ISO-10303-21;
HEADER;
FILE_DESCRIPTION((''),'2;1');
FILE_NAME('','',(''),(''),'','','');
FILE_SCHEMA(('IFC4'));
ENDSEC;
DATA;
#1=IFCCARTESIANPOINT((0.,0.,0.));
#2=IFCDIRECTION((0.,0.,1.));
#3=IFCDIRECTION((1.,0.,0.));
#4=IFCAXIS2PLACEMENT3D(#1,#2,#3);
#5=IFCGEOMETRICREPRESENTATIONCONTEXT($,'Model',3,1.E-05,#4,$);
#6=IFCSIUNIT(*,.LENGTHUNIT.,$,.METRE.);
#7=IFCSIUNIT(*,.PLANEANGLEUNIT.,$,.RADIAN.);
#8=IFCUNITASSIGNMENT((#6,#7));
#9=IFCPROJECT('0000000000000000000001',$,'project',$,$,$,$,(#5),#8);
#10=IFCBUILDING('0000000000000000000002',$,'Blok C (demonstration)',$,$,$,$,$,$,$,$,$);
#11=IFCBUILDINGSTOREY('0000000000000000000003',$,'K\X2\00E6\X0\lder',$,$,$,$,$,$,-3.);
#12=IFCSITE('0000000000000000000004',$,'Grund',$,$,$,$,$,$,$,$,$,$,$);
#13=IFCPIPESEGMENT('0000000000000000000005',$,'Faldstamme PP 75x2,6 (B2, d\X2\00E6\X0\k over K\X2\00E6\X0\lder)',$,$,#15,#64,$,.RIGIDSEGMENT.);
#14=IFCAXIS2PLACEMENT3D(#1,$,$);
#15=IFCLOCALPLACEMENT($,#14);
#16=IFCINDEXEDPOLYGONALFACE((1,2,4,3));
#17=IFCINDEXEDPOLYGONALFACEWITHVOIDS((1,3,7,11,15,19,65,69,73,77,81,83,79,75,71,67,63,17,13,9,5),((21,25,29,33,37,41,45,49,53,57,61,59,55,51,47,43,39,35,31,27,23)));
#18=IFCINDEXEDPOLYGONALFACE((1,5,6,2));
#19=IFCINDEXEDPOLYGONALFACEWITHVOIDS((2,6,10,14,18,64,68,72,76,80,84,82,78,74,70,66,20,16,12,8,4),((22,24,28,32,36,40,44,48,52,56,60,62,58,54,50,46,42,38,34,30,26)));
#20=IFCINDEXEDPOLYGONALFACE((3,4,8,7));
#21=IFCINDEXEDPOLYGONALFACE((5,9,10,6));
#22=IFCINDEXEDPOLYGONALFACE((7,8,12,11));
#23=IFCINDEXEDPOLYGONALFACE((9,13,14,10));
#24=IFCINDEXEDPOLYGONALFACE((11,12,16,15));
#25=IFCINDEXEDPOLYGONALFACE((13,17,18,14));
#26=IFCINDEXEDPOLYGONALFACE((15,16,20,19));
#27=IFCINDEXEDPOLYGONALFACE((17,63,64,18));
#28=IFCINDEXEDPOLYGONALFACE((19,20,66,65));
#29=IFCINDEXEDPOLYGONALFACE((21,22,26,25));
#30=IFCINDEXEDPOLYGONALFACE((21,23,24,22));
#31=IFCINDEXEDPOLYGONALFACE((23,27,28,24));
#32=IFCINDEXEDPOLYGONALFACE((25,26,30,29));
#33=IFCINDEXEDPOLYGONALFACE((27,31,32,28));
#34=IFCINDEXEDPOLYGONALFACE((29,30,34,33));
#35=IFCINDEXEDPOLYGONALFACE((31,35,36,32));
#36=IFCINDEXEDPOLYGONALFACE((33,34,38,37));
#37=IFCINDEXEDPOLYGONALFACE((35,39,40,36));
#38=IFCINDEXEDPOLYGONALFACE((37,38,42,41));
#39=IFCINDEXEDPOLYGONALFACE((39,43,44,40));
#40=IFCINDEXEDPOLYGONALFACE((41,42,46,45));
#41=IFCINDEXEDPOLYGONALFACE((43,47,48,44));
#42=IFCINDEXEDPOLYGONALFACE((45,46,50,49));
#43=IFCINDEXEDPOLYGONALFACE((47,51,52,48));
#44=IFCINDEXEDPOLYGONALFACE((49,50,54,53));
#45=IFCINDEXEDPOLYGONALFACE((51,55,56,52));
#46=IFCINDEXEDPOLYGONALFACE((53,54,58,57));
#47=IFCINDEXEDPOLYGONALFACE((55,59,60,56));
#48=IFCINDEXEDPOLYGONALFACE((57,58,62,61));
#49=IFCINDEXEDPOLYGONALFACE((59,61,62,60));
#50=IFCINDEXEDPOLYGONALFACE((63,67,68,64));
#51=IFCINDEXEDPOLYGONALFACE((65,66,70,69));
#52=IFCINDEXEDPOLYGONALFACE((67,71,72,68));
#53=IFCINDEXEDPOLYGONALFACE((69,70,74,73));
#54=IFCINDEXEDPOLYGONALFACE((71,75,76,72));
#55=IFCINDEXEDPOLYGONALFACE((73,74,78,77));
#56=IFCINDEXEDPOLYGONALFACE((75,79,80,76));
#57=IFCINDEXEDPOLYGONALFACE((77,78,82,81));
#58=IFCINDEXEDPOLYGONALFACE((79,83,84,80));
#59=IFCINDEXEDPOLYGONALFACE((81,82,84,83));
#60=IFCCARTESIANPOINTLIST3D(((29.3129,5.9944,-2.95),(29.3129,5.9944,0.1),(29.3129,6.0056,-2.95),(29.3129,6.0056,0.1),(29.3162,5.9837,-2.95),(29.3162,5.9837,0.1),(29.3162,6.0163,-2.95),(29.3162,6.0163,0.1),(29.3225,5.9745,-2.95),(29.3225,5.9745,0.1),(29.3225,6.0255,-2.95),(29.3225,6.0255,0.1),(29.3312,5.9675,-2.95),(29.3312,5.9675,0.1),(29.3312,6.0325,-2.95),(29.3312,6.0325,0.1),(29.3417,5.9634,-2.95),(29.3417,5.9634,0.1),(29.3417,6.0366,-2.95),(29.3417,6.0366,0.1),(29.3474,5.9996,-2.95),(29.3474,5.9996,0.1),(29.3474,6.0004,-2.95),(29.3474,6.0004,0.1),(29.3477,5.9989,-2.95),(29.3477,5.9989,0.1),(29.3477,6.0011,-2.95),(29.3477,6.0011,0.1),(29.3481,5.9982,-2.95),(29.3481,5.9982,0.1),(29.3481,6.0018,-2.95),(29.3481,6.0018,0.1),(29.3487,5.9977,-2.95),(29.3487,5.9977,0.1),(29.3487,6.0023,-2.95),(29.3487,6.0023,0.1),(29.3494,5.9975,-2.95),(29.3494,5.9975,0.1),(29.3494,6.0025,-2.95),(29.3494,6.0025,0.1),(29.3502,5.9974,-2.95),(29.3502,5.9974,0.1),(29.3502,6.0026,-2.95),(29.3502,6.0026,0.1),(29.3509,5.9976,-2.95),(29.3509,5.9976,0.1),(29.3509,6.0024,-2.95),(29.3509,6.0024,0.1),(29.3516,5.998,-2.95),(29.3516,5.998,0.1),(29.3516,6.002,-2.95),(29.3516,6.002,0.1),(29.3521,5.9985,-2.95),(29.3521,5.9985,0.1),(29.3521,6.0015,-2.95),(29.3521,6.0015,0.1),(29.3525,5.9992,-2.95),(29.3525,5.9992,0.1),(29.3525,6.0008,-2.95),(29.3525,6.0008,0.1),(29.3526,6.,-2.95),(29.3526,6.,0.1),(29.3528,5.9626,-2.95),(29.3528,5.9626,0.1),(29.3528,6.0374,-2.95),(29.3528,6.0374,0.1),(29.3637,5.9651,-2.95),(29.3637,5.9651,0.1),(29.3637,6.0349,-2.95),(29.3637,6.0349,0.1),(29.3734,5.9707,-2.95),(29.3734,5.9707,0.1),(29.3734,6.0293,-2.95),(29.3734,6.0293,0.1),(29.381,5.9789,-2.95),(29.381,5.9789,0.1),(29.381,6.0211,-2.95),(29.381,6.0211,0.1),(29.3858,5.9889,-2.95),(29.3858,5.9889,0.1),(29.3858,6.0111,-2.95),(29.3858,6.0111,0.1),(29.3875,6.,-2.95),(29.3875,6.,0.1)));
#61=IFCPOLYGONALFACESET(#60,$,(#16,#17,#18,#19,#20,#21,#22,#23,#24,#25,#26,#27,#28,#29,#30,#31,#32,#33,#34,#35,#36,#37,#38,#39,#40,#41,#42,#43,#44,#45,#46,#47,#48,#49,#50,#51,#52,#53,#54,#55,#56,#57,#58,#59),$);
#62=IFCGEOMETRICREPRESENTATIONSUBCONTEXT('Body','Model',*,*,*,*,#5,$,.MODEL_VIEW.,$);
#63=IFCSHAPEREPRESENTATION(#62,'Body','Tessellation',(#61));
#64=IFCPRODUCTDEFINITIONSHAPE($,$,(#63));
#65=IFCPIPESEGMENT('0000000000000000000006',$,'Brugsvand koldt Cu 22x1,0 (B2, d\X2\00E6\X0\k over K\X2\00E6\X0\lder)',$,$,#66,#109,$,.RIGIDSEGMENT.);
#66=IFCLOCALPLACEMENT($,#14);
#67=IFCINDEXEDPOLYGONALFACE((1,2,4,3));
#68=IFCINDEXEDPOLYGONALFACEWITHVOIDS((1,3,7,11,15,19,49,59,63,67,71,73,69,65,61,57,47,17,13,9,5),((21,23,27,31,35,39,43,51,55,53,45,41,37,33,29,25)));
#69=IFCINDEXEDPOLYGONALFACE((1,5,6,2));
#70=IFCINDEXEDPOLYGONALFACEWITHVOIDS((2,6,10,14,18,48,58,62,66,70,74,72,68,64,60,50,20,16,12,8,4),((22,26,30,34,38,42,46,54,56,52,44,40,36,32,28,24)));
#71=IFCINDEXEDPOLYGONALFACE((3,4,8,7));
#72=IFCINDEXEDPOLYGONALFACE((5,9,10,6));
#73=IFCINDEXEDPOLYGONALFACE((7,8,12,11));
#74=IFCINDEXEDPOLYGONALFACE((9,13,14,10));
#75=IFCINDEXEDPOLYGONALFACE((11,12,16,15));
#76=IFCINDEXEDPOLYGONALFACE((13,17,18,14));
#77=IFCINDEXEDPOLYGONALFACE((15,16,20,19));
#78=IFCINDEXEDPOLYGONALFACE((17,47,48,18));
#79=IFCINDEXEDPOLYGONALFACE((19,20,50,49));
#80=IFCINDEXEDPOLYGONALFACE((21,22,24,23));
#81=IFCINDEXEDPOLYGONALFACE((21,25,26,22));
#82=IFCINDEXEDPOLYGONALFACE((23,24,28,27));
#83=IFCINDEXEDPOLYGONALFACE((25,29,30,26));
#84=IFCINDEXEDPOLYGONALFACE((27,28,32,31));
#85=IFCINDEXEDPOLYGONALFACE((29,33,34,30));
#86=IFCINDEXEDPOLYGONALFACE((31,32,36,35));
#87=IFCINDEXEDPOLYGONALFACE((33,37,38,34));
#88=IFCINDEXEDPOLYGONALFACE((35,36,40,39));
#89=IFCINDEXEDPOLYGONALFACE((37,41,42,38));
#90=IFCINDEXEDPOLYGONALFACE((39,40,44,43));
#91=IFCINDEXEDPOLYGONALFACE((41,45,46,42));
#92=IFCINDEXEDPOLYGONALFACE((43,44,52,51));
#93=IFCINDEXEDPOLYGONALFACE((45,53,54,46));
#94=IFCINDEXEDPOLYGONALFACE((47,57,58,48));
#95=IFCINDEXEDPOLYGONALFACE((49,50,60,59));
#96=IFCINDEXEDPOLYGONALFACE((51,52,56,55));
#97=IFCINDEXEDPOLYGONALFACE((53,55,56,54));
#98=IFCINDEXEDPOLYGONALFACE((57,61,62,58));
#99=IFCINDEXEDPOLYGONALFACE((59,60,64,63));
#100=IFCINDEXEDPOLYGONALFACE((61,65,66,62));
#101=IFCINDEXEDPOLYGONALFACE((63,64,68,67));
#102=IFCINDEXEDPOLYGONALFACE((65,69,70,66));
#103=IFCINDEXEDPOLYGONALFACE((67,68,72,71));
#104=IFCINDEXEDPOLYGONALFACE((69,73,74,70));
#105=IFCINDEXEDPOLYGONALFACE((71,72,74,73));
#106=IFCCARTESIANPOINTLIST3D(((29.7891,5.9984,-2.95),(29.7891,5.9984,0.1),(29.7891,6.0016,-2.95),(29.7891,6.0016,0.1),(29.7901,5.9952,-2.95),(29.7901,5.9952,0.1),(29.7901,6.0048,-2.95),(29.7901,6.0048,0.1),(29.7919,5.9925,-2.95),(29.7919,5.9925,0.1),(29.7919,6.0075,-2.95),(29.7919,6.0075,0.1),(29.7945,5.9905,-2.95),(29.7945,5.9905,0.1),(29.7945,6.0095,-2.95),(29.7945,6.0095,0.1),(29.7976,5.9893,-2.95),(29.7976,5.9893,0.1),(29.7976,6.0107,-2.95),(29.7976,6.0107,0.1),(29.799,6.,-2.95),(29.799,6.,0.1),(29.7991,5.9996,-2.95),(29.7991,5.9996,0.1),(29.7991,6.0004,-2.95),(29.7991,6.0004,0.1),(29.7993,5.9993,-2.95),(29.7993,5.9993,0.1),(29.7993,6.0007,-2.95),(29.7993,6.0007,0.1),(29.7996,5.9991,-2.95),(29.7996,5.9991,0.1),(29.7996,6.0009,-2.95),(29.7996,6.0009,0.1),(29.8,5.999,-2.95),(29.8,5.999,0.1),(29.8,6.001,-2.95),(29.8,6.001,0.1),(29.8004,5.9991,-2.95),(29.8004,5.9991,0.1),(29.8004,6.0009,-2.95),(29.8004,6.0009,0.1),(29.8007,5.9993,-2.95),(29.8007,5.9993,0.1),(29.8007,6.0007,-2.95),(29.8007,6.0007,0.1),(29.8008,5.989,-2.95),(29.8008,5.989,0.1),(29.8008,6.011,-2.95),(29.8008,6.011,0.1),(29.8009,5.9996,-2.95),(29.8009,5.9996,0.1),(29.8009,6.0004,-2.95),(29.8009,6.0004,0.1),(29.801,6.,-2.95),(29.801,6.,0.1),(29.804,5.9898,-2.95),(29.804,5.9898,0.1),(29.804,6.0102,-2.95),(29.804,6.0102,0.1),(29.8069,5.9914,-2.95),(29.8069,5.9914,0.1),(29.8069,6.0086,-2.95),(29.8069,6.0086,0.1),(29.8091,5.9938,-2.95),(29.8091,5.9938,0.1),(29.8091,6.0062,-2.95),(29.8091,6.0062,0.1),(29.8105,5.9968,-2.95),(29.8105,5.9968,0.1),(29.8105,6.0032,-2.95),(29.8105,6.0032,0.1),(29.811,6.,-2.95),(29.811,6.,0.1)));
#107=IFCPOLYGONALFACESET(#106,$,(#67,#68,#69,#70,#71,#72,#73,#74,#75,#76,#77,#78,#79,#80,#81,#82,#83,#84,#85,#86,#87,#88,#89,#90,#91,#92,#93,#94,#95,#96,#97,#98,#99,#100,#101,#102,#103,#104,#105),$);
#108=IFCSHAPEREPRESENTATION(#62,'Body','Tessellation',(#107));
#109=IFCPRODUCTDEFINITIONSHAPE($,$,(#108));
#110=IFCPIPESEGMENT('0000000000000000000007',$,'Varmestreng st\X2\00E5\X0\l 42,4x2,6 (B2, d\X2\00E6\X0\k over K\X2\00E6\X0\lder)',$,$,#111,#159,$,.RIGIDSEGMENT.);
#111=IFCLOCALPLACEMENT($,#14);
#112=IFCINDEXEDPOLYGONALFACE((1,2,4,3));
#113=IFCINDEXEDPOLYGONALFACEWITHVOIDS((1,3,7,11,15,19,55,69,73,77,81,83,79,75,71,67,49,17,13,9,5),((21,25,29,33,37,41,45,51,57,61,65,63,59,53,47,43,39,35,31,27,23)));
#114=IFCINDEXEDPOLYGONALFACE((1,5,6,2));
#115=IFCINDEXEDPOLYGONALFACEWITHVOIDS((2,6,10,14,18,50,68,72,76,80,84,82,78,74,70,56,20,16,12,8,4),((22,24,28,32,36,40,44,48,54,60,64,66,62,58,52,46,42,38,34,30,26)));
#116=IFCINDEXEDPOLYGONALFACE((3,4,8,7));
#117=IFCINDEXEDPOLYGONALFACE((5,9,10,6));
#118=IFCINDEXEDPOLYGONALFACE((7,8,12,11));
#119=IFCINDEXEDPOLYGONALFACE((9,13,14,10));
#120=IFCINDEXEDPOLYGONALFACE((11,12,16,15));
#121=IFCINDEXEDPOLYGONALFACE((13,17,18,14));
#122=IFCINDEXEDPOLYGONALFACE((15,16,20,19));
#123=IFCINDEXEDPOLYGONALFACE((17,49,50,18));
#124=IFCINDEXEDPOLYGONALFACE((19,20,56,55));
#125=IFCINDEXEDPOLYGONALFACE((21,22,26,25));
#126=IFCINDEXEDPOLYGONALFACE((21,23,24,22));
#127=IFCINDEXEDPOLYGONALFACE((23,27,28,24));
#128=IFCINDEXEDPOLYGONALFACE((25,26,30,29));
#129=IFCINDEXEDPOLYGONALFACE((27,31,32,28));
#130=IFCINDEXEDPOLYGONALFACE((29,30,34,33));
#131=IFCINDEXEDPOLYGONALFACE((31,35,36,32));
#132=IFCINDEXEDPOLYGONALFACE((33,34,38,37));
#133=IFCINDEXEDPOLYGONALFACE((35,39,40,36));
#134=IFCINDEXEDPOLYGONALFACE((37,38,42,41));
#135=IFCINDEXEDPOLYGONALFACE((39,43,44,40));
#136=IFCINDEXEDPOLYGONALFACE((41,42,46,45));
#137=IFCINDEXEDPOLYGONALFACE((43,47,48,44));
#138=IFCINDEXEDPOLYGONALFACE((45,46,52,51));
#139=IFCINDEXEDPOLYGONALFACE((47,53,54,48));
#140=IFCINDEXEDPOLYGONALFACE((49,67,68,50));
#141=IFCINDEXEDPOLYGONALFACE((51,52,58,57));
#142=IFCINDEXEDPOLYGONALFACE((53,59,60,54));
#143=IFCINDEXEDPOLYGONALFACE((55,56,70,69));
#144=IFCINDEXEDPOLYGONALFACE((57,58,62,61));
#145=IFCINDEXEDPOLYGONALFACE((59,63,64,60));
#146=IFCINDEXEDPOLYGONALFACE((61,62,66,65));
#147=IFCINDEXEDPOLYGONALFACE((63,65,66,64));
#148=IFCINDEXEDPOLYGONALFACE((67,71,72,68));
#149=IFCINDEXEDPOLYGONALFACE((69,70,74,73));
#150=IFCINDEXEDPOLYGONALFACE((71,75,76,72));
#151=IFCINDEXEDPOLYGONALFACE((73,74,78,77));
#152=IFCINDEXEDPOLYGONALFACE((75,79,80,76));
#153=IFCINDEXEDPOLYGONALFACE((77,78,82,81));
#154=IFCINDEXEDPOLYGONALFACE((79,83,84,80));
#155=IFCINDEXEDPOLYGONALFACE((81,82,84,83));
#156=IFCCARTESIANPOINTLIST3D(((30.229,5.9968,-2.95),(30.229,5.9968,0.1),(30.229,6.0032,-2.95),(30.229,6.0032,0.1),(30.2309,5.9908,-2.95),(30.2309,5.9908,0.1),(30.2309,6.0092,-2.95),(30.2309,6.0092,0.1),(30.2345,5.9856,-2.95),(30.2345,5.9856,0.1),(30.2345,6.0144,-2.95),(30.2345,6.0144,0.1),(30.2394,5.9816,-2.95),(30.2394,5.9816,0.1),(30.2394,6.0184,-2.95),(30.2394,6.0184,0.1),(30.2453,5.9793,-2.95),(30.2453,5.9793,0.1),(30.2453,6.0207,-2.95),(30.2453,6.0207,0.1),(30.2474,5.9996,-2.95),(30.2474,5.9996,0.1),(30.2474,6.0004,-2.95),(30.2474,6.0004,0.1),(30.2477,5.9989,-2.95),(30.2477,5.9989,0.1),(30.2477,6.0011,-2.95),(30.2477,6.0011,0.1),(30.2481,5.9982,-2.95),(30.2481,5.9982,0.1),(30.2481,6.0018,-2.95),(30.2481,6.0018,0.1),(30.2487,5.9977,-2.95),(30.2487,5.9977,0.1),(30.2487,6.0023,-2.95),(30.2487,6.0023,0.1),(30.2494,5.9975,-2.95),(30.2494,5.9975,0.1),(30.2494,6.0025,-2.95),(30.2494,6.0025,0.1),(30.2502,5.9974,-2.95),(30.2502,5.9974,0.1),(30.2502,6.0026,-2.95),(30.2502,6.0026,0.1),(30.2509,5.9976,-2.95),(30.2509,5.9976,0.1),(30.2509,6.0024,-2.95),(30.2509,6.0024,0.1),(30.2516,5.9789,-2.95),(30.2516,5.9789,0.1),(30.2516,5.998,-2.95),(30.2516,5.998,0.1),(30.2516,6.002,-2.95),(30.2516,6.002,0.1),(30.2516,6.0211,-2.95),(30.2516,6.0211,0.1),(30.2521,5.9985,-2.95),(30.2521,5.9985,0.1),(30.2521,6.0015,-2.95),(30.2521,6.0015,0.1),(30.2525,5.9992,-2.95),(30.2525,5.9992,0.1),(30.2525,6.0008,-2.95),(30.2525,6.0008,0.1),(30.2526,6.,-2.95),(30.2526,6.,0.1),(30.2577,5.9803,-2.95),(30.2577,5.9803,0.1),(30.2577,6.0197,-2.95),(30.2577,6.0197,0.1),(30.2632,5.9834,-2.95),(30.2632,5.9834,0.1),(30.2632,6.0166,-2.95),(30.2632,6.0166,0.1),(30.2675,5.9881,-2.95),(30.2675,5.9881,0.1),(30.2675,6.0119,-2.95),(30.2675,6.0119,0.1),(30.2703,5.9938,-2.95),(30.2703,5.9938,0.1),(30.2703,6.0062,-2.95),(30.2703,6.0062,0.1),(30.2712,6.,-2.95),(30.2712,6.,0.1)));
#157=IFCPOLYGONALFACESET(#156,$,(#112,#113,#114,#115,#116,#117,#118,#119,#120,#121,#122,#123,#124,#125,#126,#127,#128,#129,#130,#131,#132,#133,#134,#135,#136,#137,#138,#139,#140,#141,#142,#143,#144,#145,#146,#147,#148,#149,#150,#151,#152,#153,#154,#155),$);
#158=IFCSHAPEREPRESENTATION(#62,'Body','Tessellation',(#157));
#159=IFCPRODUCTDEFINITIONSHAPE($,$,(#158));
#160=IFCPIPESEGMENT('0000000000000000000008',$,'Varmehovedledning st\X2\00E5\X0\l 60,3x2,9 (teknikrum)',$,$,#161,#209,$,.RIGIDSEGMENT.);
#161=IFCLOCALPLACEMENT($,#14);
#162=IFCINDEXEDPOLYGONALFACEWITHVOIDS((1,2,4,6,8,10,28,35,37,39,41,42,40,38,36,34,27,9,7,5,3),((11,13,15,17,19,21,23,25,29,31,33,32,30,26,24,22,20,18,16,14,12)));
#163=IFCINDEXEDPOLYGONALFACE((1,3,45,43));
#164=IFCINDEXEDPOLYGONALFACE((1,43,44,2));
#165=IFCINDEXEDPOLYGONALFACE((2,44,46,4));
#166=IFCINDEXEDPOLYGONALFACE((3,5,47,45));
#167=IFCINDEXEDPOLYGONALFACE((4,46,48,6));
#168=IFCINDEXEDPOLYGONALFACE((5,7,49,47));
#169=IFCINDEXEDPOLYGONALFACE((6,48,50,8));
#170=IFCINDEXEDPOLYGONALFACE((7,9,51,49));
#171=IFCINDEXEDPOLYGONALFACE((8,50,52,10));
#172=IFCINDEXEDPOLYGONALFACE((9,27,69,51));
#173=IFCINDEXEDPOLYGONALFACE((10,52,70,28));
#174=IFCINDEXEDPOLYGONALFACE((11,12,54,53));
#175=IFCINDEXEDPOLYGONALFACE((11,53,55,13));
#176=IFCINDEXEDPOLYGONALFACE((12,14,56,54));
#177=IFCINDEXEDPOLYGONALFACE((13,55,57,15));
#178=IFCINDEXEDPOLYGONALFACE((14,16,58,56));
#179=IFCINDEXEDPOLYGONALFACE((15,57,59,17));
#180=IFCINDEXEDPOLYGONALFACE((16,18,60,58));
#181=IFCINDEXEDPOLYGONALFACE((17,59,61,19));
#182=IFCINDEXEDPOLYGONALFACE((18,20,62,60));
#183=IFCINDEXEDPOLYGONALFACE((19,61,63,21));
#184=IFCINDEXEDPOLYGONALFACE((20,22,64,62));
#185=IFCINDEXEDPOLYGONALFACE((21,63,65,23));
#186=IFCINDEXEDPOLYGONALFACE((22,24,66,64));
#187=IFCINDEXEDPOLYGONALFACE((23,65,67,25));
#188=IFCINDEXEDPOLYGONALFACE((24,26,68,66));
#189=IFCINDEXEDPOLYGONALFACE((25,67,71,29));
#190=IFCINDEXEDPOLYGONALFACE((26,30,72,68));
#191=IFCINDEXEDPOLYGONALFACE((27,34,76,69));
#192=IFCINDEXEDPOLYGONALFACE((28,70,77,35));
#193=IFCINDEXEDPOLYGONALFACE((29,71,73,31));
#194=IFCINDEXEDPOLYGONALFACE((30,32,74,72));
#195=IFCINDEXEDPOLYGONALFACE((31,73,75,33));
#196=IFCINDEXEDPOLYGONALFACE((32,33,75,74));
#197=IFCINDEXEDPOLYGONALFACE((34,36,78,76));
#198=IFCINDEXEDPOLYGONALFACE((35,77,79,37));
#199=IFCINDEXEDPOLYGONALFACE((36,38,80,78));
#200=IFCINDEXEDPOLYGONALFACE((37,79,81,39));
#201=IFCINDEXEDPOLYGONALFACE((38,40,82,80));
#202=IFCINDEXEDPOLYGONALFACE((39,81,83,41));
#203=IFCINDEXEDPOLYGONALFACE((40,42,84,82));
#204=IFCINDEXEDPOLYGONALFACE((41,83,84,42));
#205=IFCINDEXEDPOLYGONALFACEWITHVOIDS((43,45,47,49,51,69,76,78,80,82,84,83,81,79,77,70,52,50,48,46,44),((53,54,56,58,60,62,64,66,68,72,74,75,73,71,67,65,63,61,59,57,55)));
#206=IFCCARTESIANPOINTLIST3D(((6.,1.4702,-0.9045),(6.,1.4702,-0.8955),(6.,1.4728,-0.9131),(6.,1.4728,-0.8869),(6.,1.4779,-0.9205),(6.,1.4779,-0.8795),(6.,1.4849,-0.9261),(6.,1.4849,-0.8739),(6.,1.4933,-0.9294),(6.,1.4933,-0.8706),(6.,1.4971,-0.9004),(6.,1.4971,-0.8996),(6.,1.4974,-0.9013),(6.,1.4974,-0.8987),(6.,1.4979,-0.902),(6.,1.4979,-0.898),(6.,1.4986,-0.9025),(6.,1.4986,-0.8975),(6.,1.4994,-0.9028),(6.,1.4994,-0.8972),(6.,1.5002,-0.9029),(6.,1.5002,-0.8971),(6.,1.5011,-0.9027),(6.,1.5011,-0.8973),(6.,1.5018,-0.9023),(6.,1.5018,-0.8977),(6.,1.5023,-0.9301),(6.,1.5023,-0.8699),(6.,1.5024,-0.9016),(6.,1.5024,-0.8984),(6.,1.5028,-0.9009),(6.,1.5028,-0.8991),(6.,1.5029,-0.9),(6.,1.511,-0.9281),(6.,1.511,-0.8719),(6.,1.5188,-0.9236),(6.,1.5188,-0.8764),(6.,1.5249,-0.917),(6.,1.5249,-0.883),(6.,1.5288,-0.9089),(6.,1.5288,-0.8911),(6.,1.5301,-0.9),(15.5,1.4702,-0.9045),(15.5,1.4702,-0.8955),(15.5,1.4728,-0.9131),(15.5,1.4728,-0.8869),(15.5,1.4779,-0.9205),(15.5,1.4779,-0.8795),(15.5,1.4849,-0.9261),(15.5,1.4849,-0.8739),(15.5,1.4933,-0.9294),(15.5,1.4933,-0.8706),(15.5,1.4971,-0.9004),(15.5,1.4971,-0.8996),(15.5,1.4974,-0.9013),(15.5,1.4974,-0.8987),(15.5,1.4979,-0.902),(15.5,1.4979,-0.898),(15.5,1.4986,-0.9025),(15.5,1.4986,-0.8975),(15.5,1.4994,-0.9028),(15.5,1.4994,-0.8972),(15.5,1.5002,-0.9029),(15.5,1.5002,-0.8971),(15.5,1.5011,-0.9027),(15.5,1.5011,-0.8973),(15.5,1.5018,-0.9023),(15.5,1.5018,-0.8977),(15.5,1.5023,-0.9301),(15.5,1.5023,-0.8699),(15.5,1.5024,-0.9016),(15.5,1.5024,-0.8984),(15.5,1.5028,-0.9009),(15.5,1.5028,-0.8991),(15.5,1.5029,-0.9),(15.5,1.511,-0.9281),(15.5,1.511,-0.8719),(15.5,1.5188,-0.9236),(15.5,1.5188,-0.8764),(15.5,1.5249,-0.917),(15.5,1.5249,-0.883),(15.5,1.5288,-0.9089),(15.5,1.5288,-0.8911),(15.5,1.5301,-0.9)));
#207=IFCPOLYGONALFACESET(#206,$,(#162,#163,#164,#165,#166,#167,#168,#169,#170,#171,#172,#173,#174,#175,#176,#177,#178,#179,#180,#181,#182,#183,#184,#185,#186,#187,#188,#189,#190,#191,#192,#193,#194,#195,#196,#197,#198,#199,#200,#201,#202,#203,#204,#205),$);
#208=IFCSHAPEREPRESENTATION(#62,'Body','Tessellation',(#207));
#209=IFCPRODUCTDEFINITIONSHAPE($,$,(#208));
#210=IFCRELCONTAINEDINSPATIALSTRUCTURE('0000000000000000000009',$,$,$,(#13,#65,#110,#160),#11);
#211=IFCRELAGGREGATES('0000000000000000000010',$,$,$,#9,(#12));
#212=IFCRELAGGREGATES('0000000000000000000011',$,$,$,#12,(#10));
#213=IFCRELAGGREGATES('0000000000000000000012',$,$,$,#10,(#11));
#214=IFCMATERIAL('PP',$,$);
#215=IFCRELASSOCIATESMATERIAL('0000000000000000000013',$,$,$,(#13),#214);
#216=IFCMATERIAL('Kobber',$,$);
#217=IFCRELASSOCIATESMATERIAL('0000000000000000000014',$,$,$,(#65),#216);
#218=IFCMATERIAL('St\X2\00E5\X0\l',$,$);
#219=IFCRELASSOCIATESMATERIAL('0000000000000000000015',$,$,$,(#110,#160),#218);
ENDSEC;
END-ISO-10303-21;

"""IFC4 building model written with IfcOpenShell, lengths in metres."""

from ifc_helpers import new_model, si_unit, frame, origin_with_axes, place, context, subcontext, project, spatial, hollow_circle, extrude, material, element, save


model = new_model("IFC4")

# Units and contexts
model_context = context("Model", 3, precision=1e-05, world=origin_with_axes())
body_context = subcontext(model_context, "Body", "Model", "MODEL_VIEW")
ifc_project = project(units=[si_unit("LENGTHUNIT", "METRE"), si_unit("PLANEANGLEUNIT", "RADIAN")], contexts=[model_context])

# Site, building, storey
site = spatial("IfcSite", under=ifc_project, Name="Grund")
building = spatial("IfcBuilding", under=site, Name="Blok C (demonstration)")
storey = spatial("IfcBuildingStorey", under=building, Name="Kælder", Elevation=-3.0)

# Pipe segments
ifc_material_1 = material(Name="Kobber")
ifc_material_2 = material(Name="PP")
pipe_segment_1_placement = place(None, origin_with_axes())
element("IfcPipeSegment", 1, at=pipe_segment_1_placement, inside=storey, material=ifc_material_2, Name="Faldstamme PP 75x2,6 (B2, dæk over Kælder)", PredefinedType="RIGIDSEGMENT", context=body_context, shape_type="SweptSolid", body=[
    extrude(hollow_circle(Radius=0.0375, WallThickness=0.0349), frame((29.35, 6.0, -2.95), z_axis=(0.0, 0.0, 1.0), x_axis=(1.0, 0.0, 0.0)), (0.0, 0.0, 1.0), 3.05),
])
pipe_segment_2_placement = place(None, origin_with_axes())
element("IfcPipeSegment", 2, at=pipe_segment_2_placement, inside=storey, material=ifc_material_1, Name="Brugsvand koldt Cu 22x1,0 (B2, dæk over Kælder)", PredefinedType="RIGIDSEGMENT", context=body_context, shape_type="SweptSolid", body=[
    extrude(hollow_circle(Radius=0.011, WallThickness=0.01), frame((29.8, 6.0, -2.95), z_axis=(0.0, 0.0, 1.0), x_axis=(1.0, 0.0, 0.0)), (0.0, 0.0, 1.0), 3.05),
])
ifc_material_3 = material(Name="Stål")
pipe_segment_3_placement = place(None, origin_with_axes())
element("IfcPipeSegment", 3, at=pipe_segment_3_placement, inside=storey, material=ifc_material_3, Name="Varmestreng stål 42,4x2,6 (B2, dæk over Kælder)", PredefinedType="RIGIDSEGMENT", context=body_context, shape_type="SweptSolid", body=[
    extrude(hollow_circle(Radius=0.0212, WallThickness=0.0186), frame((30.25, 6.0, -2.95), z_axis=(0.0, 0.0, 1.0), x_axis=(1.0, 0.0, 0.0)), (0.0, 0.0, 1.0), 3.05),
])
pipe_segment_4_placement = place(None, origin_with_axes())
element("IfcPipeSegment", 4, at=pipe_segment_4_placement, inside=storey, material=ifc_material_3, Name="Varmehovedledning stål 60,3x2,9 (teknikrum)", PredefinedType="RIGIDSEGMENT", context=body_context, shape_type="SweptSolid", body=[
    extrude(hollow_circle(Radius=0.0301, WallThickness=0.0272), frame((6.0, 1.5, -0.9), z_axis=(1.0, 0.0, 0.0), x_axis=(0.0, 1.0, 0.0)), (0.0, 0.0, 1.0), 9.5),
])

save(model, "model.ifc")
